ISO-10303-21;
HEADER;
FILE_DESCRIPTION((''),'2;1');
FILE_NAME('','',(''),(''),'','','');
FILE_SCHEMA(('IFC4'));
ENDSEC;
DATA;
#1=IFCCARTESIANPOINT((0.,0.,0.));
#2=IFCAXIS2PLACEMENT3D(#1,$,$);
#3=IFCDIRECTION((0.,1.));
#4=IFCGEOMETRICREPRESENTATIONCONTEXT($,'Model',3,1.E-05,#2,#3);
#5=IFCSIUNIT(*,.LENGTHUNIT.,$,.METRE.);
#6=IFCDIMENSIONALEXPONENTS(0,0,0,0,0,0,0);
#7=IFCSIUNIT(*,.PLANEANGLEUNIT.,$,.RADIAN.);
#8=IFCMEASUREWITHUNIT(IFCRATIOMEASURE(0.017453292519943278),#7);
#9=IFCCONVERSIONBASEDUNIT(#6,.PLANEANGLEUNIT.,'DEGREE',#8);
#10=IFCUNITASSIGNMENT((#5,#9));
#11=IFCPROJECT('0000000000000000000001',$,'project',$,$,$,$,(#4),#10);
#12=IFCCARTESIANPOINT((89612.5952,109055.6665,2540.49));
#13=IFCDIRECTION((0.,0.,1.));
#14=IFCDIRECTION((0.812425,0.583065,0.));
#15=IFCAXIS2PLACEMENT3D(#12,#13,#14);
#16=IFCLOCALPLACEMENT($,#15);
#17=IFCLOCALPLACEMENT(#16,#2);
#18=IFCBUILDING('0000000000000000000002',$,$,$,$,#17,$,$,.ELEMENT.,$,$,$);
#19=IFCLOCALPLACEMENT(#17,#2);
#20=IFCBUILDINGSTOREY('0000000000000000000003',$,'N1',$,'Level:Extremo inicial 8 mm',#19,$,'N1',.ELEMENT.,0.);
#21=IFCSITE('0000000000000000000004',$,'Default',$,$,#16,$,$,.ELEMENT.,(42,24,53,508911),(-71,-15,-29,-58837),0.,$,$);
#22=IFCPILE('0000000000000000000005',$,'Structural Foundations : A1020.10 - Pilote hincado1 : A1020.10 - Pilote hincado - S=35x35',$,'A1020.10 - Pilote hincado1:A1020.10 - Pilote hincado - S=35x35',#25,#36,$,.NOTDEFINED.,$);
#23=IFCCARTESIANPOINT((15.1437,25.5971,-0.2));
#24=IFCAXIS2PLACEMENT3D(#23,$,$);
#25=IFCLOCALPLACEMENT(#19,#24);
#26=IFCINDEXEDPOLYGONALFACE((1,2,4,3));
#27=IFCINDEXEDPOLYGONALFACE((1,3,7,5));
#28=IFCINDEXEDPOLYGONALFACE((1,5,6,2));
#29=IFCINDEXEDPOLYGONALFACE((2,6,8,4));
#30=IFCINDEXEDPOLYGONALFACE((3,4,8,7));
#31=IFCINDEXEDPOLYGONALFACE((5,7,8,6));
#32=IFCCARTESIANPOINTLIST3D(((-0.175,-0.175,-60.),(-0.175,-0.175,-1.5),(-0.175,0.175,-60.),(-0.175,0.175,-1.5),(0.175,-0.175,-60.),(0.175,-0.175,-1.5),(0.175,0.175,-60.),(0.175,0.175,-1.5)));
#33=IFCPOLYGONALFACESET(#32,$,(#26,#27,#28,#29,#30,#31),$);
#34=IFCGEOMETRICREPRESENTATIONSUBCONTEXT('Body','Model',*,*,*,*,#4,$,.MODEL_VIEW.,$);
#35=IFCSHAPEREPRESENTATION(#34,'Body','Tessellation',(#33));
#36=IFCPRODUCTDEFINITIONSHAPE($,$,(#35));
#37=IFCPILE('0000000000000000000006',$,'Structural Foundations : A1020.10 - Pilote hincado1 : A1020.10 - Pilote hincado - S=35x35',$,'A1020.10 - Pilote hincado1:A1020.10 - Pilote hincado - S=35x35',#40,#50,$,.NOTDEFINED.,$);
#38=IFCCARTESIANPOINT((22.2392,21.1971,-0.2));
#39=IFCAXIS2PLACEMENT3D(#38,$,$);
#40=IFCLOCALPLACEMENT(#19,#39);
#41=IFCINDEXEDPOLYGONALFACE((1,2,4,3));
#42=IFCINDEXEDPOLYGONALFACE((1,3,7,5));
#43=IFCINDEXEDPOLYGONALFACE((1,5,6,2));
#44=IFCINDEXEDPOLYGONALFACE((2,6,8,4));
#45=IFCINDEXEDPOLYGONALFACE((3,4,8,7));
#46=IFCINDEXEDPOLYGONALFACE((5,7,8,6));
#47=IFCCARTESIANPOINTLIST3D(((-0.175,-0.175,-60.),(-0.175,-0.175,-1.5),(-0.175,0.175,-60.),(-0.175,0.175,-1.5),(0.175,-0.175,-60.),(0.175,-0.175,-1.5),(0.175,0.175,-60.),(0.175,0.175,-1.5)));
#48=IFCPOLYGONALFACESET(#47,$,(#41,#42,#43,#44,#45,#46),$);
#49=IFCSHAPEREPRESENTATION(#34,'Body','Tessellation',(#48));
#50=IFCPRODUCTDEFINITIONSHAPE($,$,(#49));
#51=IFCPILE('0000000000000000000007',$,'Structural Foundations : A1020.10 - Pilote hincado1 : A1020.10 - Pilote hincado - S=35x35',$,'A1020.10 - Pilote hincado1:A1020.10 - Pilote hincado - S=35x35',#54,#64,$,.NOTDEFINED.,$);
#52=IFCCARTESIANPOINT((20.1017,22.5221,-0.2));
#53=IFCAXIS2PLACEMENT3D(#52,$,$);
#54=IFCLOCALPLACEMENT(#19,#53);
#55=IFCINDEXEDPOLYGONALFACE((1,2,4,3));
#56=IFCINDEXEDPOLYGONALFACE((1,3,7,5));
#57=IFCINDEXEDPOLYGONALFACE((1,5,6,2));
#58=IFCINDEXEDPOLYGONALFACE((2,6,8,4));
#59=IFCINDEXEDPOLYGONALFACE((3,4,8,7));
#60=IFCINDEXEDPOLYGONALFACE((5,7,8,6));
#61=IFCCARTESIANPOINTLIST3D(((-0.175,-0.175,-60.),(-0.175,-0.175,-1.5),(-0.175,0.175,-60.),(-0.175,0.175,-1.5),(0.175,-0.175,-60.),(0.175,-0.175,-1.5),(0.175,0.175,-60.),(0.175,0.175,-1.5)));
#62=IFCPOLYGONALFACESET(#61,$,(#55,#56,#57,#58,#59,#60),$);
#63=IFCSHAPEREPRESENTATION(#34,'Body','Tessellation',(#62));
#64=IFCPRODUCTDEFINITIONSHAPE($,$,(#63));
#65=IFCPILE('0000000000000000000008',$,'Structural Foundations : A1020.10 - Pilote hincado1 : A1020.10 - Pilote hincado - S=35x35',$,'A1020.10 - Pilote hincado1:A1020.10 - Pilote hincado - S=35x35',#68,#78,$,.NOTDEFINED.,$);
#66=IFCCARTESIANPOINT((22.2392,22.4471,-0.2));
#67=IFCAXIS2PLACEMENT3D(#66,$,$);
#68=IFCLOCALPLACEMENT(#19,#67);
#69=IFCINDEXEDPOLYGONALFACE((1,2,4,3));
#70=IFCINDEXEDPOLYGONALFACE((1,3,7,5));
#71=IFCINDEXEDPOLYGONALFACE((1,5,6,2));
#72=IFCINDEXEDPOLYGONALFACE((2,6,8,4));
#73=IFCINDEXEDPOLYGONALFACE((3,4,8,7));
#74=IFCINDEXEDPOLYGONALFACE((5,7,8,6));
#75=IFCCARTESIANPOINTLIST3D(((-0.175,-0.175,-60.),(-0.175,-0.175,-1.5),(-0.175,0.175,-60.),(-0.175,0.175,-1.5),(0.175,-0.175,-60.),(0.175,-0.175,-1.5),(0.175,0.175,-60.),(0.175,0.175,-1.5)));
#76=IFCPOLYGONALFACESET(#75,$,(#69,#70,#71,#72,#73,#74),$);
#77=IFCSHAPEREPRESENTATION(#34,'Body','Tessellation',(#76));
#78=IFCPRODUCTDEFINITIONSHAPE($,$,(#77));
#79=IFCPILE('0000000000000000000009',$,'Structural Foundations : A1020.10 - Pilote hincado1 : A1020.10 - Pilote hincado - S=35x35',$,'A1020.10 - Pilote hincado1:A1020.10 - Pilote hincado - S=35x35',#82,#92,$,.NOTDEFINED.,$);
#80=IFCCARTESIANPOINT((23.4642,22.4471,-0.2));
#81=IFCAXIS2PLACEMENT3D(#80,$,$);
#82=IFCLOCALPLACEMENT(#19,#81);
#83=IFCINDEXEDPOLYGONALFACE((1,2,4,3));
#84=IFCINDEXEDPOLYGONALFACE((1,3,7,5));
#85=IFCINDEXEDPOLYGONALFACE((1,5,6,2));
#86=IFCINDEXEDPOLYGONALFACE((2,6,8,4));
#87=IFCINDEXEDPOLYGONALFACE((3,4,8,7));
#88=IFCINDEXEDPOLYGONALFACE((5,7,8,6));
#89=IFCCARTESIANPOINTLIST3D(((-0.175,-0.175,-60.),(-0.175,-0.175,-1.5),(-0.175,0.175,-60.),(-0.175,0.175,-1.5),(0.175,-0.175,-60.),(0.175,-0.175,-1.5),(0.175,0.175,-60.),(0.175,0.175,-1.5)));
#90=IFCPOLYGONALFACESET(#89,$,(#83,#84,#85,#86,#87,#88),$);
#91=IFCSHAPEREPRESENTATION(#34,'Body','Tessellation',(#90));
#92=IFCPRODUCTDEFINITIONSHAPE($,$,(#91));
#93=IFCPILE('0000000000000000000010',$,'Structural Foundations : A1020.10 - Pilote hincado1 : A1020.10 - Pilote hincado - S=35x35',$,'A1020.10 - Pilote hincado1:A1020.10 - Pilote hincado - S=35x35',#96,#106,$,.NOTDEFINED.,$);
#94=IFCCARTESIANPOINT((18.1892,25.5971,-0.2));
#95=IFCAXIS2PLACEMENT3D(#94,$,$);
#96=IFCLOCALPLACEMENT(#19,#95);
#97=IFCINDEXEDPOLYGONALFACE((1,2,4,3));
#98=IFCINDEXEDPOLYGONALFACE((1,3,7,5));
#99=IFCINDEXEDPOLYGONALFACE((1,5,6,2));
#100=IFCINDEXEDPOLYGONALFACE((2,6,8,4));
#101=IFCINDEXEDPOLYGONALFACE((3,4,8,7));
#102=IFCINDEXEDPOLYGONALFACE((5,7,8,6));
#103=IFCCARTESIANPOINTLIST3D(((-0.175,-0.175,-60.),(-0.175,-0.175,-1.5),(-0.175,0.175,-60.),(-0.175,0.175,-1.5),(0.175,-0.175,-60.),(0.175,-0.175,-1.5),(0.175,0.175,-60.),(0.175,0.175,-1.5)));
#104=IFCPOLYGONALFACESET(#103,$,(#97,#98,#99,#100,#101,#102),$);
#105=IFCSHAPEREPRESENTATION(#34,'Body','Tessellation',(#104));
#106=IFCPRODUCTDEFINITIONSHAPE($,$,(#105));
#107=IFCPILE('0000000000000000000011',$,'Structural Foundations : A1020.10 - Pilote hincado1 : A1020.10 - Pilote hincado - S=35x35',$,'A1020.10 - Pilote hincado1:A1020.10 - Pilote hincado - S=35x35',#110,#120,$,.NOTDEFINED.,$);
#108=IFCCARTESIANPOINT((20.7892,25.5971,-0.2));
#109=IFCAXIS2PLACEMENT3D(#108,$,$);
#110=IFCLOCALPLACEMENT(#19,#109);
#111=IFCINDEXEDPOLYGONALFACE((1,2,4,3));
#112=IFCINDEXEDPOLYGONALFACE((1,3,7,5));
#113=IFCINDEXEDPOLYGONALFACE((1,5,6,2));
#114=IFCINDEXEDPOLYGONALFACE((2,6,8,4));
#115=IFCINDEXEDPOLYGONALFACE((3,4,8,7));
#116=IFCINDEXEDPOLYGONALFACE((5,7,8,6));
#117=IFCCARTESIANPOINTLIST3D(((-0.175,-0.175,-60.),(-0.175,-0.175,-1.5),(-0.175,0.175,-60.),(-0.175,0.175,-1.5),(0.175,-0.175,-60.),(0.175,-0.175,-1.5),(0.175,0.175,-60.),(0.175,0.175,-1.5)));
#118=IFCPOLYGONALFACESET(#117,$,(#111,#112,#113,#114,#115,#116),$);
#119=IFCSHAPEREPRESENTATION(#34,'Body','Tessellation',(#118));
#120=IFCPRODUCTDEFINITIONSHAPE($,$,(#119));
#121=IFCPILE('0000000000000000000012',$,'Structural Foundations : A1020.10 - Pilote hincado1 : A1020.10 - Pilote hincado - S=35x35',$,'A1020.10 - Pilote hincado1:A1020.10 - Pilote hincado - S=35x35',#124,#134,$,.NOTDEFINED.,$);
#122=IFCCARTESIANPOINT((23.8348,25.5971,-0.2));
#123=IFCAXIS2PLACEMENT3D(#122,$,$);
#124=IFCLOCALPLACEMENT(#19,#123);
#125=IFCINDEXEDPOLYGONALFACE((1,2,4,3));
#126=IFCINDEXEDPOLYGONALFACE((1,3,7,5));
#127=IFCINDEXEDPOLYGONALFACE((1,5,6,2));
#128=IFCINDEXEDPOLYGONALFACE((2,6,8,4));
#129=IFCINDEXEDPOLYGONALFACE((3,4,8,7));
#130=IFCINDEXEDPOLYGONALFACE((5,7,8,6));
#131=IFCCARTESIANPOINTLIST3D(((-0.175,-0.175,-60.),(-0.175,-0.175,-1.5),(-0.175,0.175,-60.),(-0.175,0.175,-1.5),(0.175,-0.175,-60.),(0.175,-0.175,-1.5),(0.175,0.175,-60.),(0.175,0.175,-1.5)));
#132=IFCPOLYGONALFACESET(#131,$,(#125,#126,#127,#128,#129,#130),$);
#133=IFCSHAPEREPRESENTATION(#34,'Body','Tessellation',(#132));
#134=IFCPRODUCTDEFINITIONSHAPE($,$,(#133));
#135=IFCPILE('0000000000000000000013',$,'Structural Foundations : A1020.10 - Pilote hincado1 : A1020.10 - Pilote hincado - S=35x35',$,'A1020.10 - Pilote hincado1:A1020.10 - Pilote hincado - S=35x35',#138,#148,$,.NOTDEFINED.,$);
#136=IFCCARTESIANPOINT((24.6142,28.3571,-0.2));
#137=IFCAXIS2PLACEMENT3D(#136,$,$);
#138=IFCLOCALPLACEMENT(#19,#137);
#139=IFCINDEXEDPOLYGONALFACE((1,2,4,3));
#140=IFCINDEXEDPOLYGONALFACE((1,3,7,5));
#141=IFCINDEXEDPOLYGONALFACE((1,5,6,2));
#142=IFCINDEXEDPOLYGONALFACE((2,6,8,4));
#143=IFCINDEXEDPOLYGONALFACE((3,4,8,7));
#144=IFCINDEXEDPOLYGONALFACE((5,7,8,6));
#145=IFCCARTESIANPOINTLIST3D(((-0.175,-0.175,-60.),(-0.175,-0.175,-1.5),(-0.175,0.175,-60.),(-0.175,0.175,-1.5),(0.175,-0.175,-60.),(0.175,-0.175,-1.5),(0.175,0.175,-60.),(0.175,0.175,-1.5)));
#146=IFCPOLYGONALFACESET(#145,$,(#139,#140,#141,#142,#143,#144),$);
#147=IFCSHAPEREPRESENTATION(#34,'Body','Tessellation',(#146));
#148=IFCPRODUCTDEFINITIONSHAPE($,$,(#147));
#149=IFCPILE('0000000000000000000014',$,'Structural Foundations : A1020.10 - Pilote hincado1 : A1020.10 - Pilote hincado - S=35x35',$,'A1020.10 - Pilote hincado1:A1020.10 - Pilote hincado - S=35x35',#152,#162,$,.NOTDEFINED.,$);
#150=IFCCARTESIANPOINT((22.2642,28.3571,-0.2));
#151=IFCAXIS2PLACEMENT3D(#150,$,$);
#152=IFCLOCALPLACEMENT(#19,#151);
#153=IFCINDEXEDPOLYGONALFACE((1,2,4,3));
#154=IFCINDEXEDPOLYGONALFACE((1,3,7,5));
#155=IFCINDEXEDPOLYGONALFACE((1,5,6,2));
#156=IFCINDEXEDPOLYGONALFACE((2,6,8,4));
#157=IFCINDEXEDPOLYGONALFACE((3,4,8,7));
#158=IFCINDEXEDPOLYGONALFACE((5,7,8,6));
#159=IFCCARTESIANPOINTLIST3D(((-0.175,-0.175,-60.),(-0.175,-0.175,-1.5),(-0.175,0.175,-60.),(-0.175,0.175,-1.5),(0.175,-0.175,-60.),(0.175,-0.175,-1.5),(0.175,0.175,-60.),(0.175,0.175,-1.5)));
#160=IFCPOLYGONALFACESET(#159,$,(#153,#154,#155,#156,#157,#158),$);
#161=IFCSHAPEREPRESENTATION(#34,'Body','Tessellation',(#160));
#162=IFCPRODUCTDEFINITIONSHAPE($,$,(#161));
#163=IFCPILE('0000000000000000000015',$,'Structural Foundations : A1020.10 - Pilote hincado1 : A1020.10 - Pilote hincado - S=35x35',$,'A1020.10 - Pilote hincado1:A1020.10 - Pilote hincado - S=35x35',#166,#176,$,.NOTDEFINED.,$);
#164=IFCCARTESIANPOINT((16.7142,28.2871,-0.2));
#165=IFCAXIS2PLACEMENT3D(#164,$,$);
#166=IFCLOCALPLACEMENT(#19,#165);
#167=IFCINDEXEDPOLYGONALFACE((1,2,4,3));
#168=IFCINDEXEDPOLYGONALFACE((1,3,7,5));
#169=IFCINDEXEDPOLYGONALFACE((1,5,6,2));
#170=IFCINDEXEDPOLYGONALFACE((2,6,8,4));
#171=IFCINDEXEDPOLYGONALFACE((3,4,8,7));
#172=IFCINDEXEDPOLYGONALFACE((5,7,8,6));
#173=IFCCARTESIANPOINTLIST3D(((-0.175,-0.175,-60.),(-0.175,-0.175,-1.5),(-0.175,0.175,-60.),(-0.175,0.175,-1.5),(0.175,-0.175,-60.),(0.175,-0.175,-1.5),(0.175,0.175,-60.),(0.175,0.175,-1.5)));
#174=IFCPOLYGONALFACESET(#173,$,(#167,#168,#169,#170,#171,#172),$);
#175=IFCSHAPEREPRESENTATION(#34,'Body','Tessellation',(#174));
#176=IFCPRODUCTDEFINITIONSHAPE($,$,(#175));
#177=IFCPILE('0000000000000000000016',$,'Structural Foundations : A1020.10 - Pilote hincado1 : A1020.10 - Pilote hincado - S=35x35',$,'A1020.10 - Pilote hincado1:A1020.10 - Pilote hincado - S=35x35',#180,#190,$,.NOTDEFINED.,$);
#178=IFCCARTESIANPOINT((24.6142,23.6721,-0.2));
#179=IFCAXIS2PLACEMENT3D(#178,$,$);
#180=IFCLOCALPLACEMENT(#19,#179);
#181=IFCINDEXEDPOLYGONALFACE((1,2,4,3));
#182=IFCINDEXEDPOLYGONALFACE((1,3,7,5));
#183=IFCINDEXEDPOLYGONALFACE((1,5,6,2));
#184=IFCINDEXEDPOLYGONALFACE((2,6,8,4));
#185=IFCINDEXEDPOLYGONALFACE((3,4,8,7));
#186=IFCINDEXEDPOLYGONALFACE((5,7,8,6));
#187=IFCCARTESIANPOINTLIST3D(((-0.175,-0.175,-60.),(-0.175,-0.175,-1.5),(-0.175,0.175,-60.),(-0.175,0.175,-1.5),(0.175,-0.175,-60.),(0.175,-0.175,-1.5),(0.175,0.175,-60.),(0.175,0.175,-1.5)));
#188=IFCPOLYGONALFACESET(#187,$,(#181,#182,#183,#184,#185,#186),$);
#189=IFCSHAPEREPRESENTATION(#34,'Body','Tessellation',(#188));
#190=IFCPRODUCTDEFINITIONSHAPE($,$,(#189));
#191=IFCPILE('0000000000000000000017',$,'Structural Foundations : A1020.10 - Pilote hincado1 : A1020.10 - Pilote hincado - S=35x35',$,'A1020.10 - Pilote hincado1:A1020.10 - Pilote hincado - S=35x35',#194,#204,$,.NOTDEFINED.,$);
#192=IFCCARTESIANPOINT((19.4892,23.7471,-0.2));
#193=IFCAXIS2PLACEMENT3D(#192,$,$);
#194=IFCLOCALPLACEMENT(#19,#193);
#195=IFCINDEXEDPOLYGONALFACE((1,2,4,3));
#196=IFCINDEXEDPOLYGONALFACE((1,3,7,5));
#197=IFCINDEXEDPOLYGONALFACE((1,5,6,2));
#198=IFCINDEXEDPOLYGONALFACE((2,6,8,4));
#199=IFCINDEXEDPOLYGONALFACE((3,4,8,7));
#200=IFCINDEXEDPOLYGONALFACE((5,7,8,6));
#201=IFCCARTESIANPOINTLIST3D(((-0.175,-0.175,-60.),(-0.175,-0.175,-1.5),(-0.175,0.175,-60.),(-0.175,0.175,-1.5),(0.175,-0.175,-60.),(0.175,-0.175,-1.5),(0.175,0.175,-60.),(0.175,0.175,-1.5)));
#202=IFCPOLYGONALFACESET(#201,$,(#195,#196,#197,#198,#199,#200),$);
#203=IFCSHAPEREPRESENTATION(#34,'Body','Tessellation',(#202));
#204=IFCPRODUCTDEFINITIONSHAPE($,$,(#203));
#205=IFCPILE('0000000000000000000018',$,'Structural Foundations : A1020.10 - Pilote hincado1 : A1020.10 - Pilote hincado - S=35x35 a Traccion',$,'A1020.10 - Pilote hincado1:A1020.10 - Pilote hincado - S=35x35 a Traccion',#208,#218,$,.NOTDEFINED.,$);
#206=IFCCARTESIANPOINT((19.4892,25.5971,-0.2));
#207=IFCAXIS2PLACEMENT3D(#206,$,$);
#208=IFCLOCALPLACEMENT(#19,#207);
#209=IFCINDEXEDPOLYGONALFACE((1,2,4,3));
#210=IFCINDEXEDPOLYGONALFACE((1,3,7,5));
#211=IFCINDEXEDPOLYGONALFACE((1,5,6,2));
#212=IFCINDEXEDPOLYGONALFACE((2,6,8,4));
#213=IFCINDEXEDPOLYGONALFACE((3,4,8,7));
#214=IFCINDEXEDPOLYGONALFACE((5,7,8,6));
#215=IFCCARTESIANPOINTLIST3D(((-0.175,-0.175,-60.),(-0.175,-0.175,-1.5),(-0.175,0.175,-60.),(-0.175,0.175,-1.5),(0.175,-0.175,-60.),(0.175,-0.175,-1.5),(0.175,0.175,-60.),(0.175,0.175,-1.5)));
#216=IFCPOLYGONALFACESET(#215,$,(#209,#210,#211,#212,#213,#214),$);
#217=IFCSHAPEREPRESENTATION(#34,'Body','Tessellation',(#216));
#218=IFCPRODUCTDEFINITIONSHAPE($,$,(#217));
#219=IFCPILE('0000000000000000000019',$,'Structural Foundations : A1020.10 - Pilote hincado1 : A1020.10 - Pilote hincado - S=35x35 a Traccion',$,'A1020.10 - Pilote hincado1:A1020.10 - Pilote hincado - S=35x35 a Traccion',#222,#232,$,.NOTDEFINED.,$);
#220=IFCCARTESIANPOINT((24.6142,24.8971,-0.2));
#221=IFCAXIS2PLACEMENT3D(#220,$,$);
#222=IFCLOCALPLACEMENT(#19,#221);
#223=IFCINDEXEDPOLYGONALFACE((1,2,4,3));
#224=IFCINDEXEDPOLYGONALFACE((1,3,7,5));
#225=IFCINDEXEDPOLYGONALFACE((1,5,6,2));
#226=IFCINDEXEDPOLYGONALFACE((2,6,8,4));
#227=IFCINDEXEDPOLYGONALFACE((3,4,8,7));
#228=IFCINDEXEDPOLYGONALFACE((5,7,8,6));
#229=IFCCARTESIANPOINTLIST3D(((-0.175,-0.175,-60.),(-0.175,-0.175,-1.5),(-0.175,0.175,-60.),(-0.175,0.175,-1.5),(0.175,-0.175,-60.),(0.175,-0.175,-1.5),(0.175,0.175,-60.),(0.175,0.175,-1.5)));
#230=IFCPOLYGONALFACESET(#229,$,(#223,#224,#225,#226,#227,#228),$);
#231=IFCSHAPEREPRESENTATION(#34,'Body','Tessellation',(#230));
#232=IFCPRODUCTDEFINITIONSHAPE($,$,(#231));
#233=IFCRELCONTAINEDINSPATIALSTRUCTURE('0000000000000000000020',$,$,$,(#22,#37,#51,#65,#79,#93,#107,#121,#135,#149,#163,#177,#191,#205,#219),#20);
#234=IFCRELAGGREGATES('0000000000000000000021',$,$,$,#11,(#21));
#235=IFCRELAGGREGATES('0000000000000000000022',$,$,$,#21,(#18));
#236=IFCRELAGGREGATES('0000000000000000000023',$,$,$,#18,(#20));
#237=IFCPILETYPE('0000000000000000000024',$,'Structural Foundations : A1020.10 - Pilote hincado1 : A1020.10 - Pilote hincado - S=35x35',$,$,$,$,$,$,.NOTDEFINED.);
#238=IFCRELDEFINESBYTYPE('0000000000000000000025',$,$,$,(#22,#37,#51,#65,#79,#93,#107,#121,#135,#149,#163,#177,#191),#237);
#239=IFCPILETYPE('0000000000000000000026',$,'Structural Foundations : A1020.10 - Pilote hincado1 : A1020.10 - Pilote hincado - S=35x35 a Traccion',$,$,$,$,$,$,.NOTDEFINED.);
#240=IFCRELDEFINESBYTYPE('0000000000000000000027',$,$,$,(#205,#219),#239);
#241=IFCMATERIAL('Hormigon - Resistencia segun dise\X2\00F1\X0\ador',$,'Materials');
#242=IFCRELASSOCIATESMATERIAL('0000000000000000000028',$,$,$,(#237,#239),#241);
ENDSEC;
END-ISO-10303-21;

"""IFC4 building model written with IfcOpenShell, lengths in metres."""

from ifc_helpers import new_model, entity, si_unit, converted_unit, direction, frame, origin, origin_2d_with_axis, place, context, subcontext, project, spatial, polyline, segment, composite_curve, rectangle, outline, extrude, source, transform, mapped, material, material_profile, profile_set, type_object, type_shapes, element, save


model = new_model("IFC4")

# Units and contexts
model_context = context("Model", 3, precision=1e-05, world=origin(), true_north=direction((0.0, 1.0)))
body_context = subcontext(model_context, "Body", "Model", "MODEL_VIEW")
ifc_project = project(units=[si_unit("LENGTHUNIT", "METRE"), converted_unit("PLANEANGLEUNIT", "DEGREE", entity("IfcRatioMeasure", 0.017453292519943278), si_unit("PLANEANGLEUNIT", "RADIAN"), dimensions=[0, 0, 0, 0, 0, 0, 0])], contexts=[model_context])

# Site, building, storey
site_placement = place(None, frame((89612.5952, 109055.6665, 2540.49), z_axis=(0.0, 0.0, 1.0), x_axis=(0.812425, 0.583065, 0.0)))
site = spatial("IfcSite", under=ifc_project, at=site_placement, Name="Default", CompositionType="ELEMENT", RefLatitude=(42, 24, 53, 508911), RefLongitude=(-71, -15, -29, -58837), RefElevation=0.0)
building_placement = place(site_placement, origin())
building = spatial("IfcBuilding", under=site, at=building_placement, CompositionType="ELEMENT")
storey_placement = place(building_placement, origin())
storey = spatial("IfcBuildingStorey", under=building, at=storey_placement, Name="N1", ObjectType="Level:Extremo inicial 8 mm", LongName="N1", CompositionType="ELEMENT", Elevation=0.0)

# Piles
ifc_material_1 = material(Name="Hormigon - Resistencia segun diseñador", Category="Materials")
ifc_material_profile_1 = material_profile(ifc_material_1, outline(composite_curve([segment(polyline([(0.175, 0.175, -60.0), (0.175, -0.175, -60.0)]), True, "CONTINUOUS"), segment(polyline([(0.175, -0.175, -60.0), (-0.175, -0.175, -60.0)]), True, "CONTINUOUS"), segment(polyline([(-0.175, -0.175, -60.0), (-0.175, 0.175, -60.0)]), True, "CONTINUOUS"), segment(polyline([(-0.175, 0.175, -60.0), (0.175, 0.175, -60.0)]), True, "CONTINUOUS")], self_intersect=False), kind="CURVE"), Name="A1020.10 - Pilote hincado - S=35x35")
ifc_profile_set_1 = profile_set([ifc_material_profile_1], Name="A1020.10 - Pilote hincado - S=35x35")
pile_type_1 = type_object("IfcPileType", Name="Structural Foundations : A1020.10 - Pilote hincado1 : A1020.10 - Pilote hincado - S=35x35", PredefinedType="NOTDEFINED", material=ifc_profile_set_1)
shared_shape_1 = source(origin(), body_context, "Body", "SweptSolid", [
    extrude(rectangle(XDim=0.35, YDim=0.35, at=origin_2d_with_axis()), frame((0.0, 0.0, -60.0), z_axis=(0.0, 0.0, 1.0), x_axis=(0.0, -1.0, 0.0)), (0.0, 0.0, 1.0), 58.5),
])
type_shapes(pile_type_1, [shared_shape_1])
for number, where, name in (
    (1, (15.1437, 25.5971, -0.2), "Structural Foundations : A1020.10 - Pilote hincado1 : A1020.10 - Pilote hincado - S=35x35"),
    (2, (22.2392, 21.1971, -0.2), "Structural Foundations : A1020.10 - Pilote hincado1 : A1020.10 - Pilote hincado - S=35x35"),
    (3, (20.1017, 22.5221, -0.2), "Structural Foundations : A1020.10 - Pilote hincado1 : A1020.10 - Pilote hincado - S=35x35"),
    (4, (22.2392, 22.4471, -0.2), "Structural Foundations : A1020.10 - Pilote hincado1 : A1020.10 - Pilote hincado - S=35x35"),
    (5, (23.4642, 22.4471, -0.2), "Structural Foundations : A1020.10 - Pilote hincado1 : A1020.10 - Pilote hincado - S=35x35"),
    (6, (18.1892, 25.5971, -0.2), "Structural Foundations : A1020.10 - Pilote hincado1 : A1020.10 - Pilote hincado - S=35x35"),
    (7, (20.7892, 25.5971, -0.2), "Structural Foundations : A1020.10 - Pilote hincado1 : A1020.10 - Pilote hincado - S=35x35"),
    (8, (23.8348, 25.5971, -0.2), "Structural Foundations : A1020.10 - Pilote hincado1 : A1020.10 - Pilote hincado - S=35x35"),
    (9, (24.6142, 28.3571, -0.2), "Structural Foundations : A1020.10 - Pilote hincado1 : A1020.10 - Pilote hincado - S=35x35"),
    (10, (22.2642, 28.3571, -0.2), "Structural Foundations : A1020.10 - Pilote hincado1 : A1020.10 - Pilote hincado - S=35x35"),
    (11, (16.7142, 28.2871, -0.2), "Structural Foundations : A1020.10 - Pilote hincado1 : A1020.10 - Pilote hincado - S=35x35"),
    (12, (24.6142, 23.6721, -0.2), "Structural Foundations : A1020.10 - Pilote hincado1 : A1020.10 - Pilote hincado - S=35x35"),
    (13, (19.4892, 23.7471, -0.2), "Structural Foundations : A1020.10 - Pilote hincado1 : A1020.10 - Pilote hincado - S=35x35"),
):
    element("IfcPile", number, at=place(storey_placement, frame(where)), inside=storey, type_object=pile_type_1, Name=name, ObjectType="A1020.10 - Pilote hincado1:A1020.10 - Pilote hincado - S=35x35", PredefinedType="NOTDEFINED", context=body_context, shape_type="MappedRepresentation", body=[
        mapped(shared_shape_1, transform((0.0, 0.0, 0.0), scale=1.0)),
    ])
ifc_material_profile_2 = material_profile(ifc_material_1, outline(composite_curve([segment(polyline([(0.175, 0.175, -60.0), (0.175, -0.175, -60.0)]), True, "CONTINUOUS"), segment(polyline([(0.175, -0.175, -60.0), (-0.175, -0.175, -60.0)]), True, "CONTINUOUS"), segment(polyline([(-0.175, -0.175, -60.0), (-0.175, 0.175, -60.0)]), True, "CONTINUOUS"), segment(polyline([(-0.175, 0.175, -60.0), (0.175, 0.175, -60.0)]), True, "CONTINUOUS")], self_intersect=False), kind="CURVE"), Name="A1020.10 - Pilote hincado - S=35x35 a Traccion")
ifc_profile_set_2 = profile_set([ifc_material_profile_2], Name="A1020.10 - Pilote hincado - S=35x35 a Traccion")
pile_type_2 = type_object("IfcPileType", Name="Structural Foundations : A1020.10 - Pilote hincado1 : A1020.10 - Pilote hincado - S=35x35 a Traccion", PredefinedType="NOTDEFINED", material=ifc_profile_set_2)
shared_shape_2 = source(origin(), body_context, "Body", "SweptSolid", [
    extrude(rectangle(XDim=0.35, YDim=0.35, at=origin_2d_with_axis()), frame((0.0, 0.0, -60.0), z_axis=(0.0, 0.0, 1.0), x_axis=(0.0, -1.0, 0.0)), (0.0, 0.0, 1.0), 58.5),
])
type_shapes(pile_type_2, [shared_shape_2])
for number, where, name in (
    (14, (19.4892, 25.5971, -0.2), "Structural Foundations : A1020.10 - Pilote hincado1 : A1020.10 - Pilote hincado - S=35x35 a Traccion"),
    (15, (24.6142, 24.8971, -0.2), "Structural Foundations : A1020.10 - Pilote hincado1 : A1020.10 - Pilote hincado - S=35x35 a Traccion"),
):
    element("IfcPile", number, at=place(storey_placement, frame(where)), inside=storey, type_object=pile_type_2, Name=name, ObjectType="A1020.10 - Pilote hincado1:A1020.10 - Pilote hincado - S=35x35 a Traccion", PredefinedType="NOTDEFINED", context=body_context, shape_type="MappedRepresentation", body=[
        mapped(shared_shape_2, transform((0.0, 0.0, 0.0), scale=1.0)),
    ])

save(model, "model.ifc")
